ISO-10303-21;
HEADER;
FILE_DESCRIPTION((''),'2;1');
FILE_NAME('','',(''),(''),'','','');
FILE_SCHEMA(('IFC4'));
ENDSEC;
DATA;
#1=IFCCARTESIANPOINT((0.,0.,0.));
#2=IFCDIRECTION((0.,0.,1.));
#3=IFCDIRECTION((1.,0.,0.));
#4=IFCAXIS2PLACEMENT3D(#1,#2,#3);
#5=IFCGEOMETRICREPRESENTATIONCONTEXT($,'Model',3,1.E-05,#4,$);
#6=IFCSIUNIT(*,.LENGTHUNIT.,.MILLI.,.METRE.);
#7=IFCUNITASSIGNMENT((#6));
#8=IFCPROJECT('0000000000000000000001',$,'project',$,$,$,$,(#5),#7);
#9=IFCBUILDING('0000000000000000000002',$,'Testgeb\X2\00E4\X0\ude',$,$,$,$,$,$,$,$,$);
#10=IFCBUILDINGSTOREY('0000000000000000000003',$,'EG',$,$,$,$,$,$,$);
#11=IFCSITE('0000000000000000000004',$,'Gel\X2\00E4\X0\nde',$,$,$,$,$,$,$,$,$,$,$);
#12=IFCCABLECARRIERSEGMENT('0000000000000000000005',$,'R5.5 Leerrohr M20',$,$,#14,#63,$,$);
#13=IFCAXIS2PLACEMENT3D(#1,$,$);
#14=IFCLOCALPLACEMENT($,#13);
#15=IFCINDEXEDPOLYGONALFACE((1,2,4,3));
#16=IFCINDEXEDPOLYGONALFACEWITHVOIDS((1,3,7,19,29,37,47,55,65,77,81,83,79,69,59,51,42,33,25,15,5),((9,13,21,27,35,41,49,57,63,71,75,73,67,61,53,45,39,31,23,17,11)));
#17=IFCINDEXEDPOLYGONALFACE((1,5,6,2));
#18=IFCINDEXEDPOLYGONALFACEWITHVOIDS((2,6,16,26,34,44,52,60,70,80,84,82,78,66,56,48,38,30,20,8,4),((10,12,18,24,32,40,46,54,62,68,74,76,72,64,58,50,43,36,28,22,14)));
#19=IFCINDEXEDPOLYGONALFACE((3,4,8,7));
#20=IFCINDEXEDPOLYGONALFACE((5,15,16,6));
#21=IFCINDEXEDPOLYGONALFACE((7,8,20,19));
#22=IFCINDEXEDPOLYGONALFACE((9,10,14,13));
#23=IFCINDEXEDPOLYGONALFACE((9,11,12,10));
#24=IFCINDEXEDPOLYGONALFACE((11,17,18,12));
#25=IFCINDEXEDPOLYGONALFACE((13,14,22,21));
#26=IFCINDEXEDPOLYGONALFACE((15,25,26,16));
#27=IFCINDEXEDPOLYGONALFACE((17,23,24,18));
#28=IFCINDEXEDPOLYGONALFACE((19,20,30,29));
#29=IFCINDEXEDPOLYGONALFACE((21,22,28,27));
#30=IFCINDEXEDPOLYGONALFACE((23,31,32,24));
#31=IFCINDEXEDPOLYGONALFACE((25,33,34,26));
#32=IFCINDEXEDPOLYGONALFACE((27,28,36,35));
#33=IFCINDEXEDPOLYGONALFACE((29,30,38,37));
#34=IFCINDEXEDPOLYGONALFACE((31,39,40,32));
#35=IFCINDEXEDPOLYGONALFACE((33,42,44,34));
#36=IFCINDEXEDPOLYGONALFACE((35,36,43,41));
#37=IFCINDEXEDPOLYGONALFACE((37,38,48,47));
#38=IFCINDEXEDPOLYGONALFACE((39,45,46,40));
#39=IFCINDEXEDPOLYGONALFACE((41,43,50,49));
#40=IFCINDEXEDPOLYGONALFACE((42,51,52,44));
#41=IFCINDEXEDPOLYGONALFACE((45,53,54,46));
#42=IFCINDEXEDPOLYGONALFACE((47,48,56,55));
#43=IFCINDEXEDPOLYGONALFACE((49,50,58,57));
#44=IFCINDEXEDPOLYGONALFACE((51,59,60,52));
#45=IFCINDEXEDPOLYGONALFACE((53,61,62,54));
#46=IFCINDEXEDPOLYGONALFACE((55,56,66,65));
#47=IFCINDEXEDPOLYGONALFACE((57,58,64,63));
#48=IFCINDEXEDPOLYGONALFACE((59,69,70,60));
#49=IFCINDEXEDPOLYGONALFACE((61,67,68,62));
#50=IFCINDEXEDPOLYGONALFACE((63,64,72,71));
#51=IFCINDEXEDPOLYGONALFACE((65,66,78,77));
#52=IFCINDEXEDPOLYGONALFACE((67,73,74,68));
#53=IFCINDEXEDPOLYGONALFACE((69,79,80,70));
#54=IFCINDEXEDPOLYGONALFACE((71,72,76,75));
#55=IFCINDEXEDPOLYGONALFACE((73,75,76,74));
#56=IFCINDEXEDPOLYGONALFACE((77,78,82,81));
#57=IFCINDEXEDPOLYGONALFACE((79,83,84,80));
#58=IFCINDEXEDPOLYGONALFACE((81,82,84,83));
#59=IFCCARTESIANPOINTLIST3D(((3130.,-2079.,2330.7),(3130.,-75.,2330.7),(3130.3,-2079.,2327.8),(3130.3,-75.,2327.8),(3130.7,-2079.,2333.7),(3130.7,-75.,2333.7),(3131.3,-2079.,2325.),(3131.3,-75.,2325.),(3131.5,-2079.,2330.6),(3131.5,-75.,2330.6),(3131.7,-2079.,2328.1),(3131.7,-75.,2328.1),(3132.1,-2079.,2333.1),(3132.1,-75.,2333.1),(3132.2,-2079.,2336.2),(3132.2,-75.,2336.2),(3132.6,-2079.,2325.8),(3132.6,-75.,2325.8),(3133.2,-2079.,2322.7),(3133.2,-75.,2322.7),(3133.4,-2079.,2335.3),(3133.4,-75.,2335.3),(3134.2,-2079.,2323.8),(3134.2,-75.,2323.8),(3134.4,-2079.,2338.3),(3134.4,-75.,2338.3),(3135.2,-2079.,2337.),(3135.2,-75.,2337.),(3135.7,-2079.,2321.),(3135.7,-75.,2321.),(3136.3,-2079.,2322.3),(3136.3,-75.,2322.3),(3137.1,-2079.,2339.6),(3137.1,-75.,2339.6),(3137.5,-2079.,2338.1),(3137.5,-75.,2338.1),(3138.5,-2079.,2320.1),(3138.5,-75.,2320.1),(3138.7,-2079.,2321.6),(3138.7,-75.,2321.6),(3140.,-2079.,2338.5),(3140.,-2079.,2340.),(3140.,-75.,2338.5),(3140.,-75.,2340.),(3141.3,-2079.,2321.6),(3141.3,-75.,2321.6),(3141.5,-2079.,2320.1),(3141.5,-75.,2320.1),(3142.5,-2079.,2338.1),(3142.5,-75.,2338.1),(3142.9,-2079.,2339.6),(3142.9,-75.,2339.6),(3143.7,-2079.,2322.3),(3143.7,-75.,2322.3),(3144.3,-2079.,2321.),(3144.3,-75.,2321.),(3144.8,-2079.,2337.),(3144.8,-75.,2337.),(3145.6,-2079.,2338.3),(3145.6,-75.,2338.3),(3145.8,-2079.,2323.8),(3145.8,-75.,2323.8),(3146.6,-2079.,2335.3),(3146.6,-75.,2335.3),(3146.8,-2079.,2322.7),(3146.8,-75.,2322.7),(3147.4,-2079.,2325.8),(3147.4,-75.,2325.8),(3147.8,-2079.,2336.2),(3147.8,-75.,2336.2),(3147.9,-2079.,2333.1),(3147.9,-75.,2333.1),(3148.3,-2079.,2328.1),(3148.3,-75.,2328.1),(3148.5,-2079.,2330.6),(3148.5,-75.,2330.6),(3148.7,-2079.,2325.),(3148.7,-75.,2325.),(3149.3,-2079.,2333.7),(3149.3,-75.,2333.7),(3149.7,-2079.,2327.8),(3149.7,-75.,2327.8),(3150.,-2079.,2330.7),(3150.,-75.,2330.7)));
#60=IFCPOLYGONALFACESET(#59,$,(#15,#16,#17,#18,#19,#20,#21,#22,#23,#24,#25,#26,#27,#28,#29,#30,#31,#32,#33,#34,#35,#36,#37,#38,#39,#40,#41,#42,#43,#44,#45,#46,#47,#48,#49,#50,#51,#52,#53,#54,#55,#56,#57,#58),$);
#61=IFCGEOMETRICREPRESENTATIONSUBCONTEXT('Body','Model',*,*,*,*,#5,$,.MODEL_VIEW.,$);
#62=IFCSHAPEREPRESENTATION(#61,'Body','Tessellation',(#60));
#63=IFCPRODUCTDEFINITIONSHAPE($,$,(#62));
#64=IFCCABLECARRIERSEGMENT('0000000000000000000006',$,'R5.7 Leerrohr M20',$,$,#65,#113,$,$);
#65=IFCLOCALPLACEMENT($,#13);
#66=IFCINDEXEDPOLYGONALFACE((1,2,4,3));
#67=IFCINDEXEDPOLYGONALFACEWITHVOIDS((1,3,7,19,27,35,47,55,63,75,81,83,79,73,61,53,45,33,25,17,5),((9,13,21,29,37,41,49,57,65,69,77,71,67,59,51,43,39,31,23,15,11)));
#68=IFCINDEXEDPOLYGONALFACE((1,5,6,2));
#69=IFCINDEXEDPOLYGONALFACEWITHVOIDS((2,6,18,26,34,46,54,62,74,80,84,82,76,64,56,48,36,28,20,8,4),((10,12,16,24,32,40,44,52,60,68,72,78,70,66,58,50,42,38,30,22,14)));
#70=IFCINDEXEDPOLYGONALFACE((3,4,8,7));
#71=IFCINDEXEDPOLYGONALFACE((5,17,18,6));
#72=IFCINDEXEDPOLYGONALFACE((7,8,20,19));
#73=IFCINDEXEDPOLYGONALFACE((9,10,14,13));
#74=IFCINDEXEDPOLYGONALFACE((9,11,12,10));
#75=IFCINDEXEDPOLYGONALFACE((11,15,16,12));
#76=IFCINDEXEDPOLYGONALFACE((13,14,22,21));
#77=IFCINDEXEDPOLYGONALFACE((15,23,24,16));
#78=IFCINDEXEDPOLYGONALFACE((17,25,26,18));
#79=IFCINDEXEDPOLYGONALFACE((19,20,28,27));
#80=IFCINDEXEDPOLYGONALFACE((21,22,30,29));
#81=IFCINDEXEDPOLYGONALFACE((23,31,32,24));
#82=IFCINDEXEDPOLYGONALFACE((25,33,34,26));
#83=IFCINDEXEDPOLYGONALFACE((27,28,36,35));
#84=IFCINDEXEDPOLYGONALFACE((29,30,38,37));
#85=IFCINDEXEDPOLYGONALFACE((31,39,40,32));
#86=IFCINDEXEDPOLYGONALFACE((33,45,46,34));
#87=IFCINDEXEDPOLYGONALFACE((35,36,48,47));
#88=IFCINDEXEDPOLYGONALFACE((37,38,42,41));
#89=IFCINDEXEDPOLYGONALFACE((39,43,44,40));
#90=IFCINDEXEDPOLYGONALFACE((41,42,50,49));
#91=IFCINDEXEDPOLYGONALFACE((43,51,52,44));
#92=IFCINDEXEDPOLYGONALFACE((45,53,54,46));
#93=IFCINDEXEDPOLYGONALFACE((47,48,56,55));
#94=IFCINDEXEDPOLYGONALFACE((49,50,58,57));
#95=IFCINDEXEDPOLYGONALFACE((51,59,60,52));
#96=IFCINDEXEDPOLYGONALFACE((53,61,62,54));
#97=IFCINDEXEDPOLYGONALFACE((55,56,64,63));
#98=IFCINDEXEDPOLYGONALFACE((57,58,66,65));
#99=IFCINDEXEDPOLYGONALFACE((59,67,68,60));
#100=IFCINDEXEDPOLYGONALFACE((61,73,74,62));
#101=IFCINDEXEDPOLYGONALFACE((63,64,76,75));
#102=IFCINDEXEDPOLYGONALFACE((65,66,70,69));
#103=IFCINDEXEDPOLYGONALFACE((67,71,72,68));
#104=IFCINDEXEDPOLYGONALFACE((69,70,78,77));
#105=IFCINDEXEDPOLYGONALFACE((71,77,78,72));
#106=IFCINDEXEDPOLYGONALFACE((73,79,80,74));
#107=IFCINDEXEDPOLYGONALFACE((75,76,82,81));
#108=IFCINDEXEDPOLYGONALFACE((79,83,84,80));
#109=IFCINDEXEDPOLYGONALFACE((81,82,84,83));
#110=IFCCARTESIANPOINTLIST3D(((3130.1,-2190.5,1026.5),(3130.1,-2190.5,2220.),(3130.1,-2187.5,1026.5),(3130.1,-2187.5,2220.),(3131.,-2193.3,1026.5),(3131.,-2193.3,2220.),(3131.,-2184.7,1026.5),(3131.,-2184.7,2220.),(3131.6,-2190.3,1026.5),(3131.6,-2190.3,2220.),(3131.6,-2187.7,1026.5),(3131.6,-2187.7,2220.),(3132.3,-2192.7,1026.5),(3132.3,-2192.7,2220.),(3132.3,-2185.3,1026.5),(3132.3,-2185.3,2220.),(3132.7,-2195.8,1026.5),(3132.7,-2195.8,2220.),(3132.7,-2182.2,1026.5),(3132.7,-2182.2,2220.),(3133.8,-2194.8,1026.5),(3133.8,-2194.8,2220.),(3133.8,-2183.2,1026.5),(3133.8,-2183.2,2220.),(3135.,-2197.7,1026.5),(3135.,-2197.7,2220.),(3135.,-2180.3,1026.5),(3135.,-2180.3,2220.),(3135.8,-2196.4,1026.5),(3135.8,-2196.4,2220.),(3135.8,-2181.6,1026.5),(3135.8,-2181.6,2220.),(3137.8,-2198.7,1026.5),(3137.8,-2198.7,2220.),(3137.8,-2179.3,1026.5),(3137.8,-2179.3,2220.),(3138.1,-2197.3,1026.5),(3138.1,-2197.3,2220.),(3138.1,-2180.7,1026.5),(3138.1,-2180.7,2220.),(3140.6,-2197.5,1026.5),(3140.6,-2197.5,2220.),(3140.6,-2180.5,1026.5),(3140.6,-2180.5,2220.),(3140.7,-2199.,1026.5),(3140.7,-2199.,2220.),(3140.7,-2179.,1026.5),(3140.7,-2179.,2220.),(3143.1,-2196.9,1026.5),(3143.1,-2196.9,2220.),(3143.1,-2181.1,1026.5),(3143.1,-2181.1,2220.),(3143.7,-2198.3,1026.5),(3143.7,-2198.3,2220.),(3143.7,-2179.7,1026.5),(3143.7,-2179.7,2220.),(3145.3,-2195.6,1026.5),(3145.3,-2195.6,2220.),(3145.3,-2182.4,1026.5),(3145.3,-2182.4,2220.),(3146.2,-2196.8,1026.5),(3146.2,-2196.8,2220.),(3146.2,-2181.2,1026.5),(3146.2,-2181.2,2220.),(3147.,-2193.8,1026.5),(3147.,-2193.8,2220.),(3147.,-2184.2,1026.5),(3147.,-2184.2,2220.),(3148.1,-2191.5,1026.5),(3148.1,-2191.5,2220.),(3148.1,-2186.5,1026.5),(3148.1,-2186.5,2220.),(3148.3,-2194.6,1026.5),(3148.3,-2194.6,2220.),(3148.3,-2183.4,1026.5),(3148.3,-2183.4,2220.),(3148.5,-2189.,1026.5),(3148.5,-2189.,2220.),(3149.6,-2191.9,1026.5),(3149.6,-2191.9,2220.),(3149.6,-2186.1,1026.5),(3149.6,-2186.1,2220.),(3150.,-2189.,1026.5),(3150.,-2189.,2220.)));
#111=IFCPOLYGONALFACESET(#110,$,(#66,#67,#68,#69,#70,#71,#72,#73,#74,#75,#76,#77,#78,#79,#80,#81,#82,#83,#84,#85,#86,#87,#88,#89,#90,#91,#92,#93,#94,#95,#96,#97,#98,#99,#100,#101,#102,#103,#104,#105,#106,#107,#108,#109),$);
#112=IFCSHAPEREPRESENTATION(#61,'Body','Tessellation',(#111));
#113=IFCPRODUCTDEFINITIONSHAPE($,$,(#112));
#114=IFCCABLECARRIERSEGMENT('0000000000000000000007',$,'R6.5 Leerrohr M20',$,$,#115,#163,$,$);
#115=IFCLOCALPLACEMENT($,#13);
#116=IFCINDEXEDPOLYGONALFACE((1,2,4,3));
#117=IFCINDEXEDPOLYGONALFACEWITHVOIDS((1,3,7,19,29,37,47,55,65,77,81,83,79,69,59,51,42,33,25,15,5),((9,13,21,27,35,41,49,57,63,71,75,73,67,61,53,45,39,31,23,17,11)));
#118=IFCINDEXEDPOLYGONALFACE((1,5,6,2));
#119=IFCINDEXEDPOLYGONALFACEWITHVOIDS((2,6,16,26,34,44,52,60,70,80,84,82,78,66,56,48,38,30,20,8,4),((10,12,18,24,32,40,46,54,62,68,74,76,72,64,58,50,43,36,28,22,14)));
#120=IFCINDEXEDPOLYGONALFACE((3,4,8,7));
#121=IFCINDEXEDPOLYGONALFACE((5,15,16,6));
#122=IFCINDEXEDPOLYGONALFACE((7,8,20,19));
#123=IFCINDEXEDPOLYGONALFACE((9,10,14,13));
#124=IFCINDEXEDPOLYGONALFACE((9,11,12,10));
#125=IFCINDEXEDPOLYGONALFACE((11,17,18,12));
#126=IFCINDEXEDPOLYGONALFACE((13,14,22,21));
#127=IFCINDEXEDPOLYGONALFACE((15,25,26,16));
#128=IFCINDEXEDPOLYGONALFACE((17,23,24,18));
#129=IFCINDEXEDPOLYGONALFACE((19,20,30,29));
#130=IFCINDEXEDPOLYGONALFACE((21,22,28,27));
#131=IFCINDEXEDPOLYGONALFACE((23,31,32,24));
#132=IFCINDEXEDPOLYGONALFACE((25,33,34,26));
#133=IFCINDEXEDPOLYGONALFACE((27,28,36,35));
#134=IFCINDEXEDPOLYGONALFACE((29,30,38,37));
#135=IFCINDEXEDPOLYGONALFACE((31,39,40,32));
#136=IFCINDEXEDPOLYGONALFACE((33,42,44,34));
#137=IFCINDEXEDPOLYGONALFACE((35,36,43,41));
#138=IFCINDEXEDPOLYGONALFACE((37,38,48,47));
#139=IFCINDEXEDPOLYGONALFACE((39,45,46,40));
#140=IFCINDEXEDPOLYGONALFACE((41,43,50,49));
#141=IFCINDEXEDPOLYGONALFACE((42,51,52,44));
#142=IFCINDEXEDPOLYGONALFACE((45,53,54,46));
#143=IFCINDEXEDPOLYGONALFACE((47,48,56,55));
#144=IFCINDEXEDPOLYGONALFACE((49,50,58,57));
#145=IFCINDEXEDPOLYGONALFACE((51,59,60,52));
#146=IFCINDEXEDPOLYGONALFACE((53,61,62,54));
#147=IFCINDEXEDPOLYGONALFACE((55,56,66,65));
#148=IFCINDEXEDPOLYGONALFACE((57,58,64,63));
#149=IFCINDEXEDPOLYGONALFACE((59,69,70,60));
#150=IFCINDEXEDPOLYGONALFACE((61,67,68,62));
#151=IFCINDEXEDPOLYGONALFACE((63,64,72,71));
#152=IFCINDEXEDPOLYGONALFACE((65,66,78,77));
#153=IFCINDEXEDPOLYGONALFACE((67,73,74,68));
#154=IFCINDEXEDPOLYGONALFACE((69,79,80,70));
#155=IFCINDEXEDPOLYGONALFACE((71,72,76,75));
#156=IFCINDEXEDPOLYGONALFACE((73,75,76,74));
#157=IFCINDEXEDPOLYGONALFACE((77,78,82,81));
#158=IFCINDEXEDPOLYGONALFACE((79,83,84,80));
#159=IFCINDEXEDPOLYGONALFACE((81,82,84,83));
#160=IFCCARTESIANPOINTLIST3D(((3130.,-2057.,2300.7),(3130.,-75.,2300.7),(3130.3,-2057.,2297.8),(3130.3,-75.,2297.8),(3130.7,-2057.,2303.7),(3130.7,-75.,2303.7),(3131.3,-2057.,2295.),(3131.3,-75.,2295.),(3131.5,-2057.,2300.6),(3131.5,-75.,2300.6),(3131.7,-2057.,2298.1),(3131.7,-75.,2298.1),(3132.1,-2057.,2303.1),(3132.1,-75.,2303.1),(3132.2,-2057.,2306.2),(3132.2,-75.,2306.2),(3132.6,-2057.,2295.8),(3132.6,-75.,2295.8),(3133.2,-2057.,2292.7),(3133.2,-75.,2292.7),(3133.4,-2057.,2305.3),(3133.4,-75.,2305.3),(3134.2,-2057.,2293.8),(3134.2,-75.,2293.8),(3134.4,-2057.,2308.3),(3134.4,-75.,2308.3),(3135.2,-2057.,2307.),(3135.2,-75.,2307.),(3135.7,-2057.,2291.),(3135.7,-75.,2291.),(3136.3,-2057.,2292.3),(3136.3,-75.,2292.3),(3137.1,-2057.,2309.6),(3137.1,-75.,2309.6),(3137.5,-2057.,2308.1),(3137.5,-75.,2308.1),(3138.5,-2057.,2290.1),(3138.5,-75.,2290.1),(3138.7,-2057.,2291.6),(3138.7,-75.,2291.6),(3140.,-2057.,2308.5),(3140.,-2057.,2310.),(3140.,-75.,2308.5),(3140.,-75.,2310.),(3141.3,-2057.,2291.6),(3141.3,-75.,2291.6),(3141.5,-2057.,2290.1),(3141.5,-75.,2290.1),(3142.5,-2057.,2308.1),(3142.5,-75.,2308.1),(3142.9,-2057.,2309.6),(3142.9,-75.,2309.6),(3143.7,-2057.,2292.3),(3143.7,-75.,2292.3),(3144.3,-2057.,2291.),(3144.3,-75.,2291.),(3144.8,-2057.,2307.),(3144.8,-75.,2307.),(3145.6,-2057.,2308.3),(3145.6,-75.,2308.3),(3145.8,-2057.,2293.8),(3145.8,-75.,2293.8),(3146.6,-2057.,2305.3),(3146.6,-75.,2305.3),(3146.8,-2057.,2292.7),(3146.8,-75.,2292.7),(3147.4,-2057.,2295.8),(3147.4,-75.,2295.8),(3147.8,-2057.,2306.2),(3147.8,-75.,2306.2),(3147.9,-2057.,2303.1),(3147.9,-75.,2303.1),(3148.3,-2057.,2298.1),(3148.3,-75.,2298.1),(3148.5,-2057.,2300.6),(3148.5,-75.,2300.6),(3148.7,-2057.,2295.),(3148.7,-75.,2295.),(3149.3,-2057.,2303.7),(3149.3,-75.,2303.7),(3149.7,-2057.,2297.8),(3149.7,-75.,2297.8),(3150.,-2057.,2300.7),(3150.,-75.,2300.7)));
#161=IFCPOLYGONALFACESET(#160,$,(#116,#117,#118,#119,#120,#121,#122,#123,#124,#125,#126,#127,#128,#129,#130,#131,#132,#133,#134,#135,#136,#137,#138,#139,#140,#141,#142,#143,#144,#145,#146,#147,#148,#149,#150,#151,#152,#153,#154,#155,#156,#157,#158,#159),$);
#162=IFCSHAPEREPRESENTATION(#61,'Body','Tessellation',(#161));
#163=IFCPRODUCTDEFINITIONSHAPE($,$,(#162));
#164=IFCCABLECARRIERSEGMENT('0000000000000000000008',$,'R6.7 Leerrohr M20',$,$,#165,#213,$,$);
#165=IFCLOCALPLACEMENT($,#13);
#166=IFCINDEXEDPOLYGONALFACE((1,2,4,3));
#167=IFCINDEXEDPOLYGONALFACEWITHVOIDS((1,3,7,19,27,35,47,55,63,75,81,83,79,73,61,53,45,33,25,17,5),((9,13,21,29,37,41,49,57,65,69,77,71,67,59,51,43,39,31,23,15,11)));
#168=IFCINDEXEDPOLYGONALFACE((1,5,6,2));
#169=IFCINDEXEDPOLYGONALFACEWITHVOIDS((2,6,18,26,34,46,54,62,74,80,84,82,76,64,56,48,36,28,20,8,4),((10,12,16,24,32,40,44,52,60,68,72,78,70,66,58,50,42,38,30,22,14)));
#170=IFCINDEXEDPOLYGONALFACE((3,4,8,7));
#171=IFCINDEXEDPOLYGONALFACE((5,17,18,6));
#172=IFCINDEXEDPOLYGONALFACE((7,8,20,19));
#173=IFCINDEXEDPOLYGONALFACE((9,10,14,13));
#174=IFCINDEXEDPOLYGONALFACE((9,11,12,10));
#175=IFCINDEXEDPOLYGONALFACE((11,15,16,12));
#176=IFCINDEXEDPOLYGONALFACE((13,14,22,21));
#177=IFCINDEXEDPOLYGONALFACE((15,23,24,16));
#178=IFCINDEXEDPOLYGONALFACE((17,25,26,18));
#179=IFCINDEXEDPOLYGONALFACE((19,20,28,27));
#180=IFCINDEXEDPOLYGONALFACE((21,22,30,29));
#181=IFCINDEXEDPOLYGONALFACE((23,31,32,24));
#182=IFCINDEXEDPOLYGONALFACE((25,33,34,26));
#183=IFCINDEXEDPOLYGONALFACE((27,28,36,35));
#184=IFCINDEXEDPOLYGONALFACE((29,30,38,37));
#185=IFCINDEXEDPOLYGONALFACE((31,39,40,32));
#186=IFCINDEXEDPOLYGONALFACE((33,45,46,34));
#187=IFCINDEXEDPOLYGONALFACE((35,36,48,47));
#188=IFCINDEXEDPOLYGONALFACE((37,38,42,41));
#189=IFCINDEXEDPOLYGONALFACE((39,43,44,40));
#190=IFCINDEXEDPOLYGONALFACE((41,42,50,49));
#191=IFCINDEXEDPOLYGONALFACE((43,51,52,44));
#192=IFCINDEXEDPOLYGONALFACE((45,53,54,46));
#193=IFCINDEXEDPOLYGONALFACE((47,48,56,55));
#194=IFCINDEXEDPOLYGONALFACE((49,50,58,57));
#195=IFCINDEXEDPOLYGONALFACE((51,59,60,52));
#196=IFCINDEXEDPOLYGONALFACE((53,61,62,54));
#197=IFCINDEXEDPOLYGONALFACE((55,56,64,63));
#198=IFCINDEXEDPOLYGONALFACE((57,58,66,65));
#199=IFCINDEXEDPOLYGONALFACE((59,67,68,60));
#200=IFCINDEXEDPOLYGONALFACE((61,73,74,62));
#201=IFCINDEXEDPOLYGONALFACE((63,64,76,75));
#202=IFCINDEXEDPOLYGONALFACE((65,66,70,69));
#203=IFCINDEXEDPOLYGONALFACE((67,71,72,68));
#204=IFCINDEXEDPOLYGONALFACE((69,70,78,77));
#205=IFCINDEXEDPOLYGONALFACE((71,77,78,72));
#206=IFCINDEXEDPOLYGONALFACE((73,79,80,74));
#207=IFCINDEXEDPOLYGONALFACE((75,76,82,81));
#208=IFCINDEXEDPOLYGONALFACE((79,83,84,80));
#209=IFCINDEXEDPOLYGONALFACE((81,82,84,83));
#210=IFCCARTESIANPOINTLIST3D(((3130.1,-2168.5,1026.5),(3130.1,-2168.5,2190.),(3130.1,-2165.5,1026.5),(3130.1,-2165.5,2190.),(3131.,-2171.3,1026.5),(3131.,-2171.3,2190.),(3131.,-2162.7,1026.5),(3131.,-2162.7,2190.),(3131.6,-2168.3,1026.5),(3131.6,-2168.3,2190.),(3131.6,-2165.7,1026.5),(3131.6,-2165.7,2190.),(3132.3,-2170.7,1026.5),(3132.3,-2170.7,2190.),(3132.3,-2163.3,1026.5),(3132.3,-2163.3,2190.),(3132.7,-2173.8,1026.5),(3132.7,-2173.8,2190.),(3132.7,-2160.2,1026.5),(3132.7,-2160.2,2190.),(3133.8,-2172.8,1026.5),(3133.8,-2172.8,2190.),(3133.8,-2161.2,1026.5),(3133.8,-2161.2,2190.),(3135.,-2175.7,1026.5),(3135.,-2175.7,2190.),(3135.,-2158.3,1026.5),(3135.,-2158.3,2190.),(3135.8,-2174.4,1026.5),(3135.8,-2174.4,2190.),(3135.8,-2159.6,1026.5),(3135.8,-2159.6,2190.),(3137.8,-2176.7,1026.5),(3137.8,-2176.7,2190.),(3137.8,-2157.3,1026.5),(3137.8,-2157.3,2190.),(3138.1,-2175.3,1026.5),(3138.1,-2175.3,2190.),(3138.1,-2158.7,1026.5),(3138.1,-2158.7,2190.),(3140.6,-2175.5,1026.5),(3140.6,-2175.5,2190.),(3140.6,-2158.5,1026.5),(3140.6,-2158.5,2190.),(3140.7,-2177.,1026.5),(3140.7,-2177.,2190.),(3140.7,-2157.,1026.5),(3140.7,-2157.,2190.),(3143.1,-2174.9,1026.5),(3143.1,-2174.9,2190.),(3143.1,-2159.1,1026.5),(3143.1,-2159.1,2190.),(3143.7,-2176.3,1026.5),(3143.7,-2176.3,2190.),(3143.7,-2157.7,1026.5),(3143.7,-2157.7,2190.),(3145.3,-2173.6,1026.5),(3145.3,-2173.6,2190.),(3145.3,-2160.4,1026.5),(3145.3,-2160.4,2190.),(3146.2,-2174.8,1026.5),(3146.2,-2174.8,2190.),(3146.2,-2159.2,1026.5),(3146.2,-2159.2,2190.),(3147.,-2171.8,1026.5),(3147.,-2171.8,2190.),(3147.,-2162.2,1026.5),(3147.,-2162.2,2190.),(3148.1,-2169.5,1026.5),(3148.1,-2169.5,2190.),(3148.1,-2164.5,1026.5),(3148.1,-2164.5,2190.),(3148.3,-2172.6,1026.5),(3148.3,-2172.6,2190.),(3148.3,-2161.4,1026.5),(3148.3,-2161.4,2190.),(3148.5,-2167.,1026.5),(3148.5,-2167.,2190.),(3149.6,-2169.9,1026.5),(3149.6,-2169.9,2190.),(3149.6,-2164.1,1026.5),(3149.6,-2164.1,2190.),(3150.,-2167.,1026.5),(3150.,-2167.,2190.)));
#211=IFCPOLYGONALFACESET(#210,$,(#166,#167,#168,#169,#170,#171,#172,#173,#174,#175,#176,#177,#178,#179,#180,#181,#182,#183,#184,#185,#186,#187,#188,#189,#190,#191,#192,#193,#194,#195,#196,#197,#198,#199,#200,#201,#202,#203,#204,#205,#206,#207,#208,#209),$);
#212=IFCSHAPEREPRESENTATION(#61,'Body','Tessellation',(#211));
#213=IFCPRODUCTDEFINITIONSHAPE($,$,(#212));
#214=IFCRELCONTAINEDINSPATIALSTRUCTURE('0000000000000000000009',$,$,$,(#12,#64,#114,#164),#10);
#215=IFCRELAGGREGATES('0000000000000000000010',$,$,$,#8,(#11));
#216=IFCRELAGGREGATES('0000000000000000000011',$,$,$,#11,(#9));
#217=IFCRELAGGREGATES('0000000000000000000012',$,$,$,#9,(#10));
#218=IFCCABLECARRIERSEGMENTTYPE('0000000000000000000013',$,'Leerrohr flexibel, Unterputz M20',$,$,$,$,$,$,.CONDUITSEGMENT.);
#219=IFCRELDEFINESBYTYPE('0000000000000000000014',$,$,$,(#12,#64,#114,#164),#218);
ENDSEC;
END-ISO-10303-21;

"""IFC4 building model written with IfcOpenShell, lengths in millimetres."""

from ifc_helpers import new_model, si_unit, frame, origin_with_axes, place, context, subcontext, project, spatial, hollow_circle, extrude, type_object, element, save


model = new_model("IFC4")

# Units and contexts
model_context = context("Model", 3, precision=1e-05, world=origin_with_axes())
body_context = subcontext(model_context, "Body", "Model", "MODEL_VIEW")
ifc_project = project(units=[si_unit("LENGTHUNIT", "METRE", prefix="MILLI")], contexts=[model_context])

# Site, building, storey
site = spatial("IfcSite", under=ifc_project, Name="Gelände")
building = spatial("IfcBuilding", under=site, Name="Testgebäude")
storey = spatial("IfcBuildingStorey", under=building, Name="EG")

# Cable carrier segments
cable_carrier_segment_type_1 = type_object("IfcCableCarrierSegmentType", Name="Leerrohr flexibel, Unterputz M20", PredefinedType="CONDUITSEGMENT")
cable_carrier_segment_1_placement = place(None, frame((3140.0, -75.0, 2330.0), z_axis=(0.0, -1.0, 0.0), x_axis=(0.0, 0.0, 1.0)))
element("IfcCableCarrierSegment", 1, at=cable_carrier_segment_1_placement, inside=storey, type_object=cable_carrier_segment_type_1, Name="R5.5 Leerrohr M20", context=body_context, shape_type="SweptSolid", body=[
    extrude(hollow_circle(Radius=10.0, WallThickness=1.5), None, (0.0, 0.0, 1.0), 2004.0),
])
cable_carrier_segment_2_placement = place(None, frame((3140.0, -2189.0, 2220.0), z_axis=(0.0, 0.0, -1.0), x_axis=(1.0, 0.0, 0.0)))
element("IfcCableCarrierSegment", 2, at=cable_carrier_segment_2_placement, inside=storey, type_object=cable_carrier_segment_type_1, Name="R5.7 Leerrohr M20", context=body_context, shape_type="SweptSolid", body=[
    extrude(hollow_circle(Radius=10.0, WallThickness=1.5), None, (0.0, 0.0, 1.0), 1193.5),
])
cable_carrier_segment_3_placement = place(None, frame((3140.0, -75.0, 2300.0), z_axis=(0.0, -1.0, 0.0), x_axis=(0.0, 0.0, 1.0)))
element("IfcCableCarrierSegment", 3, at=cable_carrier_segment_3_placement, inside=storey, type_object=cable_carrier_segment_type_1, Name="R6.5 Leerrohr M20", context=body_context, shape_type="SweptSolid", body=[
    extrude(hollow_circle(Radius=10.0, WallThickness=1.5), None, (0.0, 0.0, 1.0), 1982.0),
])
cable_carrier_segment_4_placement = place(None, frame((3140.0, -2167.0, 2190.0), z_axis=(0.0, 0.0, -1.0), x_axis=(1.0, 0.0, 0.0)))
element("IfcCableCarrierSegment", 4, at=cable_carrier_segment_4_placement, inside=storey, type_object=cable_carrier_segment_type_1, Name="R6.7 Leerrohr M20", context=body_context, shape_type="SweptSolid", body=[
    extrude(hollow_circle(Radius=10.0, WallThickness=1.5), None, (0.0, 0.0, 1.0), 1163.5),
])

save(model, "model.ifc")
